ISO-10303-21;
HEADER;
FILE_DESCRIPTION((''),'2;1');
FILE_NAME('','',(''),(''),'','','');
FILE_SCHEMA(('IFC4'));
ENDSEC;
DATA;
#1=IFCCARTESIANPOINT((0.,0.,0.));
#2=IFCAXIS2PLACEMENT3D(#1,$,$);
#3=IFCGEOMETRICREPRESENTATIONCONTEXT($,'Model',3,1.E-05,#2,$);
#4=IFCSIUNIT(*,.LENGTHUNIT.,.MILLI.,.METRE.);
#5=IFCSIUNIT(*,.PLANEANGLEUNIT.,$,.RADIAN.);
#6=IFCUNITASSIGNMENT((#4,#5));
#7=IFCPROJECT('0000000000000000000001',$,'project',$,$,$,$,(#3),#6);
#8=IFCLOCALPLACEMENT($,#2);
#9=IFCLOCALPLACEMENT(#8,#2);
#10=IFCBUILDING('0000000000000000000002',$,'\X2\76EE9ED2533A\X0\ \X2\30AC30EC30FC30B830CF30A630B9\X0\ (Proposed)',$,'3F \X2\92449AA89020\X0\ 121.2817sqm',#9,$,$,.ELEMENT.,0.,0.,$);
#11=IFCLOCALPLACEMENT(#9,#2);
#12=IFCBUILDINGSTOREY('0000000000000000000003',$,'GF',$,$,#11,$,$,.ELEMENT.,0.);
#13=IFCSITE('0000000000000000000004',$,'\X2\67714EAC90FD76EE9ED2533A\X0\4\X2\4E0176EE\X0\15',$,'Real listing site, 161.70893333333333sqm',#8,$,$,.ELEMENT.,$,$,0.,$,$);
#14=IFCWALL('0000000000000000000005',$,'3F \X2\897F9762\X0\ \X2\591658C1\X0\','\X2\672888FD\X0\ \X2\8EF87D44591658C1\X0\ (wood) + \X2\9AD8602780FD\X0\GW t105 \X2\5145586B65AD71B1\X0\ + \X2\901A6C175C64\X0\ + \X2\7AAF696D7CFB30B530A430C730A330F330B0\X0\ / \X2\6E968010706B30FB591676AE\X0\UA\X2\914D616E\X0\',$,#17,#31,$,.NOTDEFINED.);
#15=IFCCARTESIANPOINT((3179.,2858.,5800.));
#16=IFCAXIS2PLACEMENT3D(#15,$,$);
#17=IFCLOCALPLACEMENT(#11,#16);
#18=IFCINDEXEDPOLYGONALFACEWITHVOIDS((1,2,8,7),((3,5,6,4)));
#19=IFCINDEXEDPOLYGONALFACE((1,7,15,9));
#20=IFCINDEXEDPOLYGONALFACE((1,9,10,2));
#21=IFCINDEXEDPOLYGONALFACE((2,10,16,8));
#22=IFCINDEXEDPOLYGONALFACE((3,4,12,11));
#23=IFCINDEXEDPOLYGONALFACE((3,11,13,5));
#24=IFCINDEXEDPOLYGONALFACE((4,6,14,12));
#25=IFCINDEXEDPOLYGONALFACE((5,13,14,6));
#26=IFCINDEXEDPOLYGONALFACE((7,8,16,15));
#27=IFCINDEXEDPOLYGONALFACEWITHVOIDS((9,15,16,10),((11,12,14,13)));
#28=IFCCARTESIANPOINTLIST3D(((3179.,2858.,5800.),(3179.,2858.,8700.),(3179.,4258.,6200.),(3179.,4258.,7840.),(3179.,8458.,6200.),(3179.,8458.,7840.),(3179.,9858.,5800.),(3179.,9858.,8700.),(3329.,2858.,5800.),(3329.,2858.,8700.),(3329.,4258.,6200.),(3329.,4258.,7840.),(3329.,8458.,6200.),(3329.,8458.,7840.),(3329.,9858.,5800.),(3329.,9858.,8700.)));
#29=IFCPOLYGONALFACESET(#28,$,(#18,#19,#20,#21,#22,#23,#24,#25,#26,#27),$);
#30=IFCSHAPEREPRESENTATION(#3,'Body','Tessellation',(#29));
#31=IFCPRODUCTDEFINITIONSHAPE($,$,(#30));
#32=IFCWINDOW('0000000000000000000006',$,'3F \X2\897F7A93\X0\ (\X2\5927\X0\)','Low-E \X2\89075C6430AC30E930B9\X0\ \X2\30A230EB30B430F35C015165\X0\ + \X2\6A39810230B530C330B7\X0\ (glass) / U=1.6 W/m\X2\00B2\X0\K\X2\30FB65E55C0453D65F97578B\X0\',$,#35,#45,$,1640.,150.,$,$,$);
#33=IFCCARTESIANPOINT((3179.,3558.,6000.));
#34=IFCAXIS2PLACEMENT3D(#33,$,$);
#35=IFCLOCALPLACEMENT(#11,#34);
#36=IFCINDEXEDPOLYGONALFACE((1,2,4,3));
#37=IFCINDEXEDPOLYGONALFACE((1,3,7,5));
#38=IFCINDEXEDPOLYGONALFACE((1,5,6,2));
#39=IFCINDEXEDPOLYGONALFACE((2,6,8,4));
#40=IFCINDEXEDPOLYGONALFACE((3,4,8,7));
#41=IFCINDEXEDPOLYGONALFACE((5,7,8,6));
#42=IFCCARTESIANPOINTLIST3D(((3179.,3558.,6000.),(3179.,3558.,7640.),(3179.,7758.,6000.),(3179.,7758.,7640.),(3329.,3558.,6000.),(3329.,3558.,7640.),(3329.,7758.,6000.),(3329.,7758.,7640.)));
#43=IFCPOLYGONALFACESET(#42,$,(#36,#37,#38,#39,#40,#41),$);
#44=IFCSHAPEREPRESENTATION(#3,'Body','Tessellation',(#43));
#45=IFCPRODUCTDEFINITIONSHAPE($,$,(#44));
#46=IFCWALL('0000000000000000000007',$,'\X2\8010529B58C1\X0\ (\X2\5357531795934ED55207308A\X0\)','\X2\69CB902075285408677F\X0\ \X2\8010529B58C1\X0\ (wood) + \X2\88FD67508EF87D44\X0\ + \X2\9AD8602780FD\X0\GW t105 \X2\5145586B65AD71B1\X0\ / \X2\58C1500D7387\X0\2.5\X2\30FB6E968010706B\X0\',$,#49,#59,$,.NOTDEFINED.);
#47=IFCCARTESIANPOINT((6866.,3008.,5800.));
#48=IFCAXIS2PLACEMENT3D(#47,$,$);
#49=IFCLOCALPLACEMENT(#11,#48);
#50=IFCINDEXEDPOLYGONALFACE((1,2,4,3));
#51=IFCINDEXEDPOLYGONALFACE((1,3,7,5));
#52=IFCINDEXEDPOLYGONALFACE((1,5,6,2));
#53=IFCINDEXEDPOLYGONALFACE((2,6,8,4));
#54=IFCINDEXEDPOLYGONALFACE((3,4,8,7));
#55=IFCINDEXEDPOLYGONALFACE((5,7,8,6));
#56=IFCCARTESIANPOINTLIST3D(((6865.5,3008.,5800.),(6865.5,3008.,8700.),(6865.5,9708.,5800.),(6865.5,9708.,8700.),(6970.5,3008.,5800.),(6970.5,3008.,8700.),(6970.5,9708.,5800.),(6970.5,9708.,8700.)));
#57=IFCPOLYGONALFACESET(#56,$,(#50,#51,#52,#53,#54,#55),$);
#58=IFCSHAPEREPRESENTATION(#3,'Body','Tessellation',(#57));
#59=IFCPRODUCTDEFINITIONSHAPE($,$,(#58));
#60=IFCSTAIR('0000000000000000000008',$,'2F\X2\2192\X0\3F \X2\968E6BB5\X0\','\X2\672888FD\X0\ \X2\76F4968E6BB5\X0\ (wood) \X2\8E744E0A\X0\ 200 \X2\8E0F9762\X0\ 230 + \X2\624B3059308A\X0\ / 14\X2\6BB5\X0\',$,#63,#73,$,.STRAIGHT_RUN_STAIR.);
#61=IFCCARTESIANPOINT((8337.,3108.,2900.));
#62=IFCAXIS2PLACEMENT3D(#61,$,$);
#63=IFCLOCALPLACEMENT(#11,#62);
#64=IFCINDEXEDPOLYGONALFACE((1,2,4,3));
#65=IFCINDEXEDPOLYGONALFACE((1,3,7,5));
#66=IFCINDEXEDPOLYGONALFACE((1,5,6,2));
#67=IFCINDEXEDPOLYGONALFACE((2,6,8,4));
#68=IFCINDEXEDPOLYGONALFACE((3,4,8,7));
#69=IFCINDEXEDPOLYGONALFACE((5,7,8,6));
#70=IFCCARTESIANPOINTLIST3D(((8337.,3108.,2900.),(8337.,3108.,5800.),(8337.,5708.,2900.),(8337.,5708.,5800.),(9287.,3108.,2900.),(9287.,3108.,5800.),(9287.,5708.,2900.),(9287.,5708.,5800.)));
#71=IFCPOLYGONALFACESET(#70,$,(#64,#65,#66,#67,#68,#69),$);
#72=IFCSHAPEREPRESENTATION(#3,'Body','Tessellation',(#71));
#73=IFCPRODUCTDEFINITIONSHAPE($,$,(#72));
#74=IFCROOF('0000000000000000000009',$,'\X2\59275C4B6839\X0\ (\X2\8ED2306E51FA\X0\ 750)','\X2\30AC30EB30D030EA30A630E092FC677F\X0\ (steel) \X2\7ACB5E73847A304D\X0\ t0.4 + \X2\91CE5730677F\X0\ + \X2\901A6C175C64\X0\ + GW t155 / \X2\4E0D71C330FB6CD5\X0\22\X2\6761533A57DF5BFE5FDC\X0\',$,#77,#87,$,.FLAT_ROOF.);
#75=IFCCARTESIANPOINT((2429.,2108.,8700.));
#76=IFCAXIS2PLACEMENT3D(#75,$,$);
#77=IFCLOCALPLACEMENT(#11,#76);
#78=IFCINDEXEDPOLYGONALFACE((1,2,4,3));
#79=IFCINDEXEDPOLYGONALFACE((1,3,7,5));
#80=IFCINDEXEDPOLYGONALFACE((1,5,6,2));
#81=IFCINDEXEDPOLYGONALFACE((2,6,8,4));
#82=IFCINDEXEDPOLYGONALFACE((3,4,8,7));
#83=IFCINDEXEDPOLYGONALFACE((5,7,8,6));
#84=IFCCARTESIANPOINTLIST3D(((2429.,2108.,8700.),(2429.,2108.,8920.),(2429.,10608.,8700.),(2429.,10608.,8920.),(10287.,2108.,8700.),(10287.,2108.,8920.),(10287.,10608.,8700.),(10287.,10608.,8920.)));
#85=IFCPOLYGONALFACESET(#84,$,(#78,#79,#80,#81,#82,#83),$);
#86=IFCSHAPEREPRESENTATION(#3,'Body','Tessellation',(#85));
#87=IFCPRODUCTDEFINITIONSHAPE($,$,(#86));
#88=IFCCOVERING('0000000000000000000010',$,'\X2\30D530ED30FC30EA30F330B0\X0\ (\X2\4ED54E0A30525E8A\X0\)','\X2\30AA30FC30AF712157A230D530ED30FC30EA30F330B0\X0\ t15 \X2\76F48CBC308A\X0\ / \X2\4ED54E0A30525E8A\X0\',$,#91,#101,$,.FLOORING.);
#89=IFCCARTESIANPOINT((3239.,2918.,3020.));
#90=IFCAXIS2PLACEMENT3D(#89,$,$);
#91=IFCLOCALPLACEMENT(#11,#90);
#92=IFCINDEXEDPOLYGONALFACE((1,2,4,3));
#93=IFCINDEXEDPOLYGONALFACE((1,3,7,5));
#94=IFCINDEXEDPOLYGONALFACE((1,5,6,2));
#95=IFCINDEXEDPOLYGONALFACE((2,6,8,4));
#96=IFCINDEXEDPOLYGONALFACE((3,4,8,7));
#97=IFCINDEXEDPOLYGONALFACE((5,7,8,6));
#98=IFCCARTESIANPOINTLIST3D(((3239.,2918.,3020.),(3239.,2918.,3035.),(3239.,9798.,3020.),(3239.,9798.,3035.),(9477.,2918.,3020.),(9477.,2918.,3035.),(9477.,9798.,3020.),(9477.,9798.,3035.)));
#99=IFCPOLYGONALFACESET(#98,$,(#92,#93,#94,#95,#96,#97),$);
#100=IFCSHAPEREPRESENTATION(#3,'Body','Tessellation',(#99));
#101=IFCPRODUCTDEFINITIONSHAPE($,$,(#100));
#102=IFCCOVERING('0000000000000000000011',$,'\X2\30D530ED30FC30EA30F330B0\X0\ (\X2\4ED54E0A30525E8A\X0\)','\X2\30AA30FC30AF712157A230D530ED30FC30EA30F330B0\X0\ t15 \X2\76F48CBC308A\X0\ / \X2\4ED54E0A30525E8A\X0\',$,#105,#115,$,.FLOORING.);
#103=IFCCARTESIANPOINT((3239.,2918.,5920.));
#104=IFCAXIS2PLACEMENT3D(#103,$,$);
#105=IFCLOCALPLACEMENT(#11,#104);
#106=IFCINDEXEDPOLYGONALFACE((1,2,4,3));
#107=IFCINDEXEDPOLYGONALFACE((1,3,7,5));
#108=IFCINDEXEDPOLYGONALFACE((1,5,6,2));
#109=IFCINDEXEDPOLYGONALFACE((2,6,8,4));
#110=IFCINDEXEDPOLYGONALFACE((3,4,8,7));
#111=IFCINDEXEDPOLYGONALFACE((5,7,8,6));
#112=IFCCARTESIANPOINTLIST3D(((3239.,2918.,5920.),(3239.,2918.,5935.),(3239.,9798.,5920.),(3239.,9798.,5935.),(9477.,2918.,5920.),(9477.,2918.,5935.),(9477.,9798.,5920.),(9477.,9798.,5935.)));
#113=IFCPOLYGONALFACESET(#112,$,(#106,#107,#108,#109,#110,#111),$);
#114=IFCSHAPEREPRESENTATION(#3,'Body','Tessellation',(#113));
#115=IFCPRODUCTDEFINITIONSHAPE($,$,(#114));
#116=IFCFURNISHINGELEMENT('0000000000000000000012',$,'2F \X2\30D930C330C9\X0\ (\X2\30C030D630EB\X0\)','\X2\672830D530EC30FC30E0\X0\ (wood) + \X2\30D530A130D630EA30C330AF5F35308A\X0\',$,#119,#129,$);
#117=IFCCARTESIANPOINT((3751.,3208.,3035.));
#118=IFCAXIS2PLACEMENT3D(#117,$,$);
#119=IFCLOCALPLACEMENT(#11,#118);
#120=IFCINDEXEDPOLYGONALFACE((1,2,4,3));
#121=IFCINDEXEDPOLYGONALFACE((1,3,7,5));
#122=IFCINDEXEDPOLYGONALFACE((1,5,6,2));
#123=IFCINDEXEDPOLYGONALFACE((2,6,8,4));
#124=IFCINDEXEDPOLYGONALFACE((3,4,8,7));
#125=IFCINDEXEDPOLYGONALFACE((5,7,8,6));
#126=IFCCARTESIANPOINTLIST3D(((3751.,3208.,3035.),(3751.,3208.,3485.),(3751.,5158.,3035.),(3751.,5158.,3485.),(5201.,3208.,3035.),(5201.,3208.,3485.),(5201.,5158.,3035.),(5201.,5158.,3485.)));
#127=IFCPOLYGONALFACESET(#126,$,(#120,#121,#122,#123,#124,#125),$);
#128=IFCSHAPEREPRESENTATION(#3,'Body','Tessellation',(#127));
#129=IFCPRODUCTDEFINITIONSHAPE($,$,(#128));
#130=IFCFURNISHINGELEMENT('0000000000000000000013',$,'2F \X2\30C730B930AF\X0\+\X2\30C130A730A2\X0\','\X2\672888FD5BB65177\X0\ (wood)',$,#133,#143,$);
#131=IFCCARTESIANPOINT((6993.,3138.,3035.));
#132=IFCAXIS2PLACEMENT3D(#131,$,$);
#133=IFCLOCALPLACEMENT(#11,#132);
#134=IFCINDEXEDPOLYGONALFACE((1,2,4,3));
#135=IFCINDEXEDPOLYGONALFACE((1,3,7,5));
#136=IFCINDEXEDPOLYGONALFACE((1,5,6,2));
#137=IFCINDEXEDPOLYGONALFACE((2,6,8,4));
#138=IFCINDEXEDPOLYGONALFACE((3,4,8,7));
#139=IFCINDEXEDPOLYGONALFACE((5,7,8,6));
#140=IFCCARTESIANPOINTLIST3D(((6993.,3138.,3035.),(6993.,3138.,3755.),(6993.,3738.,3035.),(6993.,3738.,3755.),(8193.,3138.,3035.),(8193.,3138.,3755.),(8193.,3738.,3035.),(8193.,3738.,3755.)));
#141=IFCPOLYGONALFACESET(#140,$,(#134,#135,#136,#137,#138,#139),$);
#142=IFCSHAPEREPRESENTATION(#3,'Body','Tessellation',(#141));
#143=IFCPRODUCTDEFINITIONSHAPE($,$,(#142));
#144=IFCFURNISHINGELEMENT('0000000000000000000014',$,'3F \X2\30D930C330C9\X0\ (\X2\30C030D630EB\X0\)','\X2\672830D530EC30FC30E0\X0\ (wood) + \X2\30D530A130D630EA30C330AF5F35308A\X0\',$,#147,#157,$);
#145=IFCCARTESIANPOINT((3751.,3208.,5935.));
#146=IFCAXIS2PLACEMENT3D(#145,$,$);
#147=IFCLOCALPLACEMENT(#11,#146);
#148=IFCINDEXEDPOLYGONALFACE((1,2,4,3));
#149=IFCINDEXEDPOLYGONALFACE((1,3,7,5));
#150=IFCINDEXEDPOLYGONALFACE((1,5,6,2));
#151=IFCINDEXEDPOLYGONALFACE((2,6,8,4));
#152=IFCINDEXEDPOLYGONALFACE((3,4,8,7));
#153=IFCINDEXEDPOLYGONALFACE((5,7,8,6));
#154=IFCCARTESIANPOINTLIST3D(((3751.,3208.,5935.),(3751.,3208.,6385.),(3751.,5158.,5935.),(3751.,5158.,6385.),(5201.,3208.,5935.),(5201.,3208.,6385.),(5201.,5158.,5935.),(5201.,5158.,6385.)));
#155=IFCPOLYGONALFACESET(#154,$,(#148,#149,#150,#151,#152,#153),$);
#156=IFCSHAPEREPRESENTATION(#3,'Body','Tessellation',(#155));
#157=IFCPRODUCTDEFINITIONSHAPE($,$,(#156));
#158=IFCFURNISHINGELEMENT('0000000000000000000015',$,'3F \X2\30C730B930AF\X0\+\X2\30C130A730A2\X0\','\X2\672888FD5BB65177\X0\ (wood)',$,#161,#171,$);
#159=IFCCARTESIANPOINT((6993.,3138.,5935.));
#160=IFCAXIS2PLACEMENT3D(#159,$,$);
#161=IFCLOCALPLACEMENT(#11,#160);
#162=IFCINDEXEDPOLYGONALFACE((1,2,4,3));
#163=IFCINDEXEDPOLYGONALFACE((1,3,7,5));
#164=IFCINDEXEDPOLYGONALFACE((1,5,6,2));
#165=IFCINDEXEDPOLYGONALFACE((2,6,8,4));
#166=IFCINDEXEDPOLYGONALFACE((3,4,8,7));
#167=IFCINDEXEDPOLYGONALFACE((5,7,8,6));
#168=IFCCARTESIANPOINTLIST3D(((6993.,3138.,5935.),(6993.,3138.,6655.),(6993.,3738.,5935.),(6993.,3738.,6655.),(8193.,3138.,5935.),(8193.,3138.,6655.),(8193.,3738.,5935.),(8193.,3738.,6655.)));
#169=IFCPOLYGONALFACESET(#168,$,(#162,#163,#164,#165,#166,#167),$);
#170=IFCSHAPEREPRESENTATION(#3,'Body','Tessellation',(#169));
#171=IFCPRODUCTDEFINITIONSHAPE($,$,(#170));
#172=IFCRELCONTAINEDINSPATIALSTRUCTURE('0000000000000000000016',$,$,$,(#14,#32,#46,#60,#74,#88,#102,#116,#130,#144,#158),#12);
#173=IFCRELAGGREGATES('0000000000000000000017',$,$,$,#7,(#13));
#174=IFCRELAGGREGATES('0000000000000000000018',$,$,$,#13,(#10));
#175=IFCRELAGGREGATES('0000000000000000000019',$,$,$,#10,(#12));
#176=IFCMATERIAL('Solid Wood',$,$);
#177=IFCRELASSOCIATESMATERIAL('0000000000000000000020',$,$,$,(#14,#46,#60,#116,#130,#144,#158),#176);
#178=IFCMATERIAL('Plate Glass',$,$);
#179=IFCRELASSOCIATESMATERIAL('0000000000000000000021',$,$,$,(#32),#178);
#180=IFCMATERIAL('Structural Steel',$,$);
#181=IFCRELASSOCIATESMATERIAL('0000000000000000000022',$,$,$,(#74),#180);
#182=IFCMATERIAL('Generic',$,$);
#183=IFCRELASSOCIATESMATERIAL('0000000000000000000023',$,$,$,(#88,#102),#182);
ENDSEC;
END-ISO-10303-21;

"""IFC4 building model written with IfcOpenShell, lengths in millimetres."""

from ifc_helpers import new_model, si_unit, frame, frame_2d, origin, place, context, project, spatial, rectangle, extrude, material, element, fill, save


model = new_model("IFC4")

# Units and contexts
model_context = context("Model", 3, precision=1e-05, world=origin())
ifc_project = project(units=[si_unit("LENGTHUNIT", "METRE", prefix="MILLI"), si_unit("PLANEANGLEUNIT", "RADIAN")], contexts=[model_context])

# Site, building, storey
site_placement = place(None, origin())
site = spatial("IfcSite", under=ifc_project, at=site_placement, Name="東京都目黒区4丁目15", ObjectType="Real listing site, 161.70893333333333sqm", CompositionType="ELEMENT", RefElevation=0.0)
building_placement = place(site_placement, origin())
building = spatial("IfcBuilding", under=site, at=building_placement, Name="目黒区 ガレージハウス (Proposed)", ObjectType="3F 鉄骨造 121.2817sqm", CompositionType="ELEMENT", ElevationOfRefHeight=0.0, ElevationOfTerrain=0.0)
storey_placement = place(building_placement, origin())
storey = spatial("IfcBuildingStorey", under=building, at=storey_placement, Name="GF", CompositionType="ELEMENT", Elevation=0.0)

# Shared definitions
ifc_material_1 = material(Name="Solid Wood")

# Shared definitions
ifc_material_2 = material(Name="Plate Glass")

# Wall, opening, window
wall_1_placement = place(storey_placement, frame((3179.0, 2858.0, 5800.0)))
wall_1 = element("IfcWall", 1, at=wall_1_placement, inside=storey, material=ifc_material_1, Name="3F 西面 外壁", Description="木製 軸組外壁 (wood) + 高性能GW t105 充填断熱 + 通気層 + 窯業系サイディング / 準耐火・外皮UA配慮", PredefinedType="NOTDEFINED", context=model_context, shape_type="SweptSolid", body=[
    extrude(rectangle(XDim=150.0, YDim=7000.0, at=frame_2d((75.0, 3500.0))), frame((3179.0, 2858.0, 5800.0)), (0.0, 0.0, 1.0), 2900.0),
])
opening_1_placement = place(storey_placement, frame((3179.0, 3558.0, 6000.0)))
opening_1 = element("IfcOpeningElement", 2, at=opening_1_placement, cuts=wall_1, PredefinedType="NOTDEFINED", context=model_context, shape_type="SweptSolid", body=[
    extrude(rectangle(XDim=150.0, YDim=4200.0, at=frame_2d((75.0, 2100.0))), frame((3179.0, 3558.0, 6000.0)), (0.0, 0.0, 1.0), 1640.0),
])
window_1_placement = place(storey_placement, frame((3179.0, 3558.0, 6000.0)))
window_1 = element("IfcWindow", 3, at=window_1_placement, inside=storey, material=ifc_material_2, Name="3F 西窓 (大)", Description="Low-E 複層ガラス アルゴン封入 + 樹脂サッシ (glass) / U=1.6 W/m²K・日射取得型", OverallHeight=1640.0, OverallWidth=150.0, context=model_context, shape_type="SweptSolid", body=[
    extrude(rectangle(XDim=150.0, YDim=4200.0, at=frame_2d((75.0, 2100.0))), frame((3179.0, 3558.0, 6000.0)), (0.0, 0.0, 1.0), 1640.0),
])
fill(opening_1, window_1)

# Wall
wall_2_placement = place(storey_placement, frame((6866.0, 3008.0, 5800.0)))
element("IfcWall", 4, at=wall_2_placement, inside=storey, material=ifc_material_1, Name="耐力壁 (南北間仕切り)", Description="構造用合板 耐力壁 (wood) + 製材軸組 + 高性能GW t105 充填断熱 / 壁倍率2.5・準耐火", PredefinedType="NOTDEFINED", context=model_context, shape_type="SweptSolid", body=[
    extrude(rectangle(XDim=105.0, YDim=6700.0, at=frame_2d((52.0, 3350.0))), frame((6866.0, 3008.0, 5800.0)), (0.0, 0.0, 1.0), 2900.0),
])

# Stair
stair_placement = place(storey_placement, frame((8337.0, 3108.0, 2900.0)))
element("IfcStair", 5, at=stair_placement, inside=storey, material=ifc_material_1, Name="2F→3F 階段", Description="木製 直階段 (wood) 蹴上 200 踏面 230 + 手すり / 14段", PredefinedType="STRAIGHT_RUN_STAIR", context=model_context, shape_type="SweptSolid", body=[
    extrude(rectangle(XDim=950.0, YDim=2600.0, at=frame_2d((475.0, 1300.0))), frame((8337.0, 3108.0, 2900.0)), (0.0, 0.0, 1.0), 2900.0),
])

# Roof
ifc_material_3 = material(Name="Structural Steel")
roof_placement = place(storey_placement, frame((2429.0, 2108.0, 8700.0)))
element("IfcRoof", 6, at=roof_placement, inside=storey, material=ifc_material_3, Name="大屋根 (軒の出 750)", Description="ガルバリウム鋼板 (steel) 立平葺き t0.4 + 野地板 + 通気層 + GW t155 / 不燃・法22条区域対応", PredefinedType="FLAT_ROOF", context=model_context, shape_type="SweptSolid", body=[
    extrude(rectangle(XDim=7858.0, YDim=8500.0, at=frame_2d((3929.0, 4250.0))), frame((2429.0, 2108.0, 8700.0)), (0.0, 0.0, 1.0), 220.0),
])

# Coverings
ifc_material_4 = material(Name="Generic")
covering_1_placement = place(storey_placement, frame((3239.0, 2918.0, 3020.0)))
element("IfcCovering", 7, at=covering_1_placement, inside=storey, material=ifc_material_4, Name="フローリング (仕上げ床)", Description="オーク無垢フローリング t15 直貼り / 仕上げ床", PredefinedType="FLOORING", context=model_context, shape_type="SweptSolid", body=[
    extrude(rectangle(XDim=6238.0, YDim=6880.0, at=frame_2d((3119.0, 3440.0))), frame((3239.0, 2918.0, 3020.0)), (0.0, 0.0, 1.0), 15.0),
])
covering_2_placement = place(storey_placement, frame((3239.0, 2918.0, 5920.0)))
element("IfcCovering", 8, at=covering_2_placement, inside=storey, material=ifc_material_4, Name="フローリング (仕上げ床)", Description="オーク無垢フローリング t15 直貼り / 仕上げ床", PredefinedType="FLOORING", context=model_context, shape_type="SweptSolid", body=[
    extrude(rectangle(XDim=6238.0, YDim=6880.0, at=frame_2d((3119.0, 3440.0))), frame((3239.0, 2918.0, 5920.0)), (0.0, 0.0, 1.0), 15.0),
])

# Furnishing elements
furnishing_1_placement = place(storey_placement, frame((3751.0, 3208.0, 3035.0)))
element("IfcFurnishingElement", 9, at=furnishing_1_placement, inside=storey, material=ifc_material_1, Name="2F ベッド (ダブル)", Description="木フレーム (wood) + ファブリック張り", context=model_context, shape_type="SweptSolid", body=[
    extrude(rectangle(XDim=1450.0, YDim=1950.0, at=frame_2d((725.0, 975.0))), frame((3751.0, 3208.0, 3035.0)), (0.0, 0.0, 1.0), 450.0),
])
furnishing_2_placement = place(storey_placement, frame((6993.0, 3138.0, 3035.0)))
element("IfcFurnishingElement", 10, at=furnishing_2_placement, inside=storey, material=ifc_material_1, Name="2F デスク+チェア", Description="木製家具 (wood)", context=model_context, shape_type="SweptSolid", body=[
    extrude(rectangle(XDim=1200.0, YDim=600.0, at=frame_2d((600.0, 300.0))), frame((6993.0, 3138.0, 3035.0)), (0.0, 0.0, 1.0), 720.0),
])
furnishing_3_placement = place(storey_placement, frame((3751.0, 3208.0, 5935.0)))
element("IfcFurnishingElement", 11, at=furnishing_3_placement, inside=storey, material=ifc_material_1, Name="3F ベッド (ダブル)", Description="木フレーム (wood) + ファブリック張り", context=model_context, shape_type="SweptSolid", body=[
    extrude(rectangle(XDim=1450.0, YDim=1950.0, at=frame_2d((725.0, 975.0))), frame((3751.0, 3208.0, 5935.0)), (0.0, 0.0, 1.0), 450.0),
])
furnishing_4_placement = place(storey_placement, frame((6993.0, 3138.0, 5935.0)))
element("IfcFurnishingElement", 12, at=furnishing_4_placement, inside=storey, material=ifc_material_1, Name="3F デスク+チェア", Description="木製家具 (wood)", context=model_context, shape_type="SweptSolid", body=[
    extrude(rectangle(XDim=1200.0, YDim=600.0, at=frame_2d((600.0, 300.0))), frame((6993.0, 3138.0, 5935.0)), (0.0, 0.0, 1.0), 720.0),
])

save(model, "model.ifc")
